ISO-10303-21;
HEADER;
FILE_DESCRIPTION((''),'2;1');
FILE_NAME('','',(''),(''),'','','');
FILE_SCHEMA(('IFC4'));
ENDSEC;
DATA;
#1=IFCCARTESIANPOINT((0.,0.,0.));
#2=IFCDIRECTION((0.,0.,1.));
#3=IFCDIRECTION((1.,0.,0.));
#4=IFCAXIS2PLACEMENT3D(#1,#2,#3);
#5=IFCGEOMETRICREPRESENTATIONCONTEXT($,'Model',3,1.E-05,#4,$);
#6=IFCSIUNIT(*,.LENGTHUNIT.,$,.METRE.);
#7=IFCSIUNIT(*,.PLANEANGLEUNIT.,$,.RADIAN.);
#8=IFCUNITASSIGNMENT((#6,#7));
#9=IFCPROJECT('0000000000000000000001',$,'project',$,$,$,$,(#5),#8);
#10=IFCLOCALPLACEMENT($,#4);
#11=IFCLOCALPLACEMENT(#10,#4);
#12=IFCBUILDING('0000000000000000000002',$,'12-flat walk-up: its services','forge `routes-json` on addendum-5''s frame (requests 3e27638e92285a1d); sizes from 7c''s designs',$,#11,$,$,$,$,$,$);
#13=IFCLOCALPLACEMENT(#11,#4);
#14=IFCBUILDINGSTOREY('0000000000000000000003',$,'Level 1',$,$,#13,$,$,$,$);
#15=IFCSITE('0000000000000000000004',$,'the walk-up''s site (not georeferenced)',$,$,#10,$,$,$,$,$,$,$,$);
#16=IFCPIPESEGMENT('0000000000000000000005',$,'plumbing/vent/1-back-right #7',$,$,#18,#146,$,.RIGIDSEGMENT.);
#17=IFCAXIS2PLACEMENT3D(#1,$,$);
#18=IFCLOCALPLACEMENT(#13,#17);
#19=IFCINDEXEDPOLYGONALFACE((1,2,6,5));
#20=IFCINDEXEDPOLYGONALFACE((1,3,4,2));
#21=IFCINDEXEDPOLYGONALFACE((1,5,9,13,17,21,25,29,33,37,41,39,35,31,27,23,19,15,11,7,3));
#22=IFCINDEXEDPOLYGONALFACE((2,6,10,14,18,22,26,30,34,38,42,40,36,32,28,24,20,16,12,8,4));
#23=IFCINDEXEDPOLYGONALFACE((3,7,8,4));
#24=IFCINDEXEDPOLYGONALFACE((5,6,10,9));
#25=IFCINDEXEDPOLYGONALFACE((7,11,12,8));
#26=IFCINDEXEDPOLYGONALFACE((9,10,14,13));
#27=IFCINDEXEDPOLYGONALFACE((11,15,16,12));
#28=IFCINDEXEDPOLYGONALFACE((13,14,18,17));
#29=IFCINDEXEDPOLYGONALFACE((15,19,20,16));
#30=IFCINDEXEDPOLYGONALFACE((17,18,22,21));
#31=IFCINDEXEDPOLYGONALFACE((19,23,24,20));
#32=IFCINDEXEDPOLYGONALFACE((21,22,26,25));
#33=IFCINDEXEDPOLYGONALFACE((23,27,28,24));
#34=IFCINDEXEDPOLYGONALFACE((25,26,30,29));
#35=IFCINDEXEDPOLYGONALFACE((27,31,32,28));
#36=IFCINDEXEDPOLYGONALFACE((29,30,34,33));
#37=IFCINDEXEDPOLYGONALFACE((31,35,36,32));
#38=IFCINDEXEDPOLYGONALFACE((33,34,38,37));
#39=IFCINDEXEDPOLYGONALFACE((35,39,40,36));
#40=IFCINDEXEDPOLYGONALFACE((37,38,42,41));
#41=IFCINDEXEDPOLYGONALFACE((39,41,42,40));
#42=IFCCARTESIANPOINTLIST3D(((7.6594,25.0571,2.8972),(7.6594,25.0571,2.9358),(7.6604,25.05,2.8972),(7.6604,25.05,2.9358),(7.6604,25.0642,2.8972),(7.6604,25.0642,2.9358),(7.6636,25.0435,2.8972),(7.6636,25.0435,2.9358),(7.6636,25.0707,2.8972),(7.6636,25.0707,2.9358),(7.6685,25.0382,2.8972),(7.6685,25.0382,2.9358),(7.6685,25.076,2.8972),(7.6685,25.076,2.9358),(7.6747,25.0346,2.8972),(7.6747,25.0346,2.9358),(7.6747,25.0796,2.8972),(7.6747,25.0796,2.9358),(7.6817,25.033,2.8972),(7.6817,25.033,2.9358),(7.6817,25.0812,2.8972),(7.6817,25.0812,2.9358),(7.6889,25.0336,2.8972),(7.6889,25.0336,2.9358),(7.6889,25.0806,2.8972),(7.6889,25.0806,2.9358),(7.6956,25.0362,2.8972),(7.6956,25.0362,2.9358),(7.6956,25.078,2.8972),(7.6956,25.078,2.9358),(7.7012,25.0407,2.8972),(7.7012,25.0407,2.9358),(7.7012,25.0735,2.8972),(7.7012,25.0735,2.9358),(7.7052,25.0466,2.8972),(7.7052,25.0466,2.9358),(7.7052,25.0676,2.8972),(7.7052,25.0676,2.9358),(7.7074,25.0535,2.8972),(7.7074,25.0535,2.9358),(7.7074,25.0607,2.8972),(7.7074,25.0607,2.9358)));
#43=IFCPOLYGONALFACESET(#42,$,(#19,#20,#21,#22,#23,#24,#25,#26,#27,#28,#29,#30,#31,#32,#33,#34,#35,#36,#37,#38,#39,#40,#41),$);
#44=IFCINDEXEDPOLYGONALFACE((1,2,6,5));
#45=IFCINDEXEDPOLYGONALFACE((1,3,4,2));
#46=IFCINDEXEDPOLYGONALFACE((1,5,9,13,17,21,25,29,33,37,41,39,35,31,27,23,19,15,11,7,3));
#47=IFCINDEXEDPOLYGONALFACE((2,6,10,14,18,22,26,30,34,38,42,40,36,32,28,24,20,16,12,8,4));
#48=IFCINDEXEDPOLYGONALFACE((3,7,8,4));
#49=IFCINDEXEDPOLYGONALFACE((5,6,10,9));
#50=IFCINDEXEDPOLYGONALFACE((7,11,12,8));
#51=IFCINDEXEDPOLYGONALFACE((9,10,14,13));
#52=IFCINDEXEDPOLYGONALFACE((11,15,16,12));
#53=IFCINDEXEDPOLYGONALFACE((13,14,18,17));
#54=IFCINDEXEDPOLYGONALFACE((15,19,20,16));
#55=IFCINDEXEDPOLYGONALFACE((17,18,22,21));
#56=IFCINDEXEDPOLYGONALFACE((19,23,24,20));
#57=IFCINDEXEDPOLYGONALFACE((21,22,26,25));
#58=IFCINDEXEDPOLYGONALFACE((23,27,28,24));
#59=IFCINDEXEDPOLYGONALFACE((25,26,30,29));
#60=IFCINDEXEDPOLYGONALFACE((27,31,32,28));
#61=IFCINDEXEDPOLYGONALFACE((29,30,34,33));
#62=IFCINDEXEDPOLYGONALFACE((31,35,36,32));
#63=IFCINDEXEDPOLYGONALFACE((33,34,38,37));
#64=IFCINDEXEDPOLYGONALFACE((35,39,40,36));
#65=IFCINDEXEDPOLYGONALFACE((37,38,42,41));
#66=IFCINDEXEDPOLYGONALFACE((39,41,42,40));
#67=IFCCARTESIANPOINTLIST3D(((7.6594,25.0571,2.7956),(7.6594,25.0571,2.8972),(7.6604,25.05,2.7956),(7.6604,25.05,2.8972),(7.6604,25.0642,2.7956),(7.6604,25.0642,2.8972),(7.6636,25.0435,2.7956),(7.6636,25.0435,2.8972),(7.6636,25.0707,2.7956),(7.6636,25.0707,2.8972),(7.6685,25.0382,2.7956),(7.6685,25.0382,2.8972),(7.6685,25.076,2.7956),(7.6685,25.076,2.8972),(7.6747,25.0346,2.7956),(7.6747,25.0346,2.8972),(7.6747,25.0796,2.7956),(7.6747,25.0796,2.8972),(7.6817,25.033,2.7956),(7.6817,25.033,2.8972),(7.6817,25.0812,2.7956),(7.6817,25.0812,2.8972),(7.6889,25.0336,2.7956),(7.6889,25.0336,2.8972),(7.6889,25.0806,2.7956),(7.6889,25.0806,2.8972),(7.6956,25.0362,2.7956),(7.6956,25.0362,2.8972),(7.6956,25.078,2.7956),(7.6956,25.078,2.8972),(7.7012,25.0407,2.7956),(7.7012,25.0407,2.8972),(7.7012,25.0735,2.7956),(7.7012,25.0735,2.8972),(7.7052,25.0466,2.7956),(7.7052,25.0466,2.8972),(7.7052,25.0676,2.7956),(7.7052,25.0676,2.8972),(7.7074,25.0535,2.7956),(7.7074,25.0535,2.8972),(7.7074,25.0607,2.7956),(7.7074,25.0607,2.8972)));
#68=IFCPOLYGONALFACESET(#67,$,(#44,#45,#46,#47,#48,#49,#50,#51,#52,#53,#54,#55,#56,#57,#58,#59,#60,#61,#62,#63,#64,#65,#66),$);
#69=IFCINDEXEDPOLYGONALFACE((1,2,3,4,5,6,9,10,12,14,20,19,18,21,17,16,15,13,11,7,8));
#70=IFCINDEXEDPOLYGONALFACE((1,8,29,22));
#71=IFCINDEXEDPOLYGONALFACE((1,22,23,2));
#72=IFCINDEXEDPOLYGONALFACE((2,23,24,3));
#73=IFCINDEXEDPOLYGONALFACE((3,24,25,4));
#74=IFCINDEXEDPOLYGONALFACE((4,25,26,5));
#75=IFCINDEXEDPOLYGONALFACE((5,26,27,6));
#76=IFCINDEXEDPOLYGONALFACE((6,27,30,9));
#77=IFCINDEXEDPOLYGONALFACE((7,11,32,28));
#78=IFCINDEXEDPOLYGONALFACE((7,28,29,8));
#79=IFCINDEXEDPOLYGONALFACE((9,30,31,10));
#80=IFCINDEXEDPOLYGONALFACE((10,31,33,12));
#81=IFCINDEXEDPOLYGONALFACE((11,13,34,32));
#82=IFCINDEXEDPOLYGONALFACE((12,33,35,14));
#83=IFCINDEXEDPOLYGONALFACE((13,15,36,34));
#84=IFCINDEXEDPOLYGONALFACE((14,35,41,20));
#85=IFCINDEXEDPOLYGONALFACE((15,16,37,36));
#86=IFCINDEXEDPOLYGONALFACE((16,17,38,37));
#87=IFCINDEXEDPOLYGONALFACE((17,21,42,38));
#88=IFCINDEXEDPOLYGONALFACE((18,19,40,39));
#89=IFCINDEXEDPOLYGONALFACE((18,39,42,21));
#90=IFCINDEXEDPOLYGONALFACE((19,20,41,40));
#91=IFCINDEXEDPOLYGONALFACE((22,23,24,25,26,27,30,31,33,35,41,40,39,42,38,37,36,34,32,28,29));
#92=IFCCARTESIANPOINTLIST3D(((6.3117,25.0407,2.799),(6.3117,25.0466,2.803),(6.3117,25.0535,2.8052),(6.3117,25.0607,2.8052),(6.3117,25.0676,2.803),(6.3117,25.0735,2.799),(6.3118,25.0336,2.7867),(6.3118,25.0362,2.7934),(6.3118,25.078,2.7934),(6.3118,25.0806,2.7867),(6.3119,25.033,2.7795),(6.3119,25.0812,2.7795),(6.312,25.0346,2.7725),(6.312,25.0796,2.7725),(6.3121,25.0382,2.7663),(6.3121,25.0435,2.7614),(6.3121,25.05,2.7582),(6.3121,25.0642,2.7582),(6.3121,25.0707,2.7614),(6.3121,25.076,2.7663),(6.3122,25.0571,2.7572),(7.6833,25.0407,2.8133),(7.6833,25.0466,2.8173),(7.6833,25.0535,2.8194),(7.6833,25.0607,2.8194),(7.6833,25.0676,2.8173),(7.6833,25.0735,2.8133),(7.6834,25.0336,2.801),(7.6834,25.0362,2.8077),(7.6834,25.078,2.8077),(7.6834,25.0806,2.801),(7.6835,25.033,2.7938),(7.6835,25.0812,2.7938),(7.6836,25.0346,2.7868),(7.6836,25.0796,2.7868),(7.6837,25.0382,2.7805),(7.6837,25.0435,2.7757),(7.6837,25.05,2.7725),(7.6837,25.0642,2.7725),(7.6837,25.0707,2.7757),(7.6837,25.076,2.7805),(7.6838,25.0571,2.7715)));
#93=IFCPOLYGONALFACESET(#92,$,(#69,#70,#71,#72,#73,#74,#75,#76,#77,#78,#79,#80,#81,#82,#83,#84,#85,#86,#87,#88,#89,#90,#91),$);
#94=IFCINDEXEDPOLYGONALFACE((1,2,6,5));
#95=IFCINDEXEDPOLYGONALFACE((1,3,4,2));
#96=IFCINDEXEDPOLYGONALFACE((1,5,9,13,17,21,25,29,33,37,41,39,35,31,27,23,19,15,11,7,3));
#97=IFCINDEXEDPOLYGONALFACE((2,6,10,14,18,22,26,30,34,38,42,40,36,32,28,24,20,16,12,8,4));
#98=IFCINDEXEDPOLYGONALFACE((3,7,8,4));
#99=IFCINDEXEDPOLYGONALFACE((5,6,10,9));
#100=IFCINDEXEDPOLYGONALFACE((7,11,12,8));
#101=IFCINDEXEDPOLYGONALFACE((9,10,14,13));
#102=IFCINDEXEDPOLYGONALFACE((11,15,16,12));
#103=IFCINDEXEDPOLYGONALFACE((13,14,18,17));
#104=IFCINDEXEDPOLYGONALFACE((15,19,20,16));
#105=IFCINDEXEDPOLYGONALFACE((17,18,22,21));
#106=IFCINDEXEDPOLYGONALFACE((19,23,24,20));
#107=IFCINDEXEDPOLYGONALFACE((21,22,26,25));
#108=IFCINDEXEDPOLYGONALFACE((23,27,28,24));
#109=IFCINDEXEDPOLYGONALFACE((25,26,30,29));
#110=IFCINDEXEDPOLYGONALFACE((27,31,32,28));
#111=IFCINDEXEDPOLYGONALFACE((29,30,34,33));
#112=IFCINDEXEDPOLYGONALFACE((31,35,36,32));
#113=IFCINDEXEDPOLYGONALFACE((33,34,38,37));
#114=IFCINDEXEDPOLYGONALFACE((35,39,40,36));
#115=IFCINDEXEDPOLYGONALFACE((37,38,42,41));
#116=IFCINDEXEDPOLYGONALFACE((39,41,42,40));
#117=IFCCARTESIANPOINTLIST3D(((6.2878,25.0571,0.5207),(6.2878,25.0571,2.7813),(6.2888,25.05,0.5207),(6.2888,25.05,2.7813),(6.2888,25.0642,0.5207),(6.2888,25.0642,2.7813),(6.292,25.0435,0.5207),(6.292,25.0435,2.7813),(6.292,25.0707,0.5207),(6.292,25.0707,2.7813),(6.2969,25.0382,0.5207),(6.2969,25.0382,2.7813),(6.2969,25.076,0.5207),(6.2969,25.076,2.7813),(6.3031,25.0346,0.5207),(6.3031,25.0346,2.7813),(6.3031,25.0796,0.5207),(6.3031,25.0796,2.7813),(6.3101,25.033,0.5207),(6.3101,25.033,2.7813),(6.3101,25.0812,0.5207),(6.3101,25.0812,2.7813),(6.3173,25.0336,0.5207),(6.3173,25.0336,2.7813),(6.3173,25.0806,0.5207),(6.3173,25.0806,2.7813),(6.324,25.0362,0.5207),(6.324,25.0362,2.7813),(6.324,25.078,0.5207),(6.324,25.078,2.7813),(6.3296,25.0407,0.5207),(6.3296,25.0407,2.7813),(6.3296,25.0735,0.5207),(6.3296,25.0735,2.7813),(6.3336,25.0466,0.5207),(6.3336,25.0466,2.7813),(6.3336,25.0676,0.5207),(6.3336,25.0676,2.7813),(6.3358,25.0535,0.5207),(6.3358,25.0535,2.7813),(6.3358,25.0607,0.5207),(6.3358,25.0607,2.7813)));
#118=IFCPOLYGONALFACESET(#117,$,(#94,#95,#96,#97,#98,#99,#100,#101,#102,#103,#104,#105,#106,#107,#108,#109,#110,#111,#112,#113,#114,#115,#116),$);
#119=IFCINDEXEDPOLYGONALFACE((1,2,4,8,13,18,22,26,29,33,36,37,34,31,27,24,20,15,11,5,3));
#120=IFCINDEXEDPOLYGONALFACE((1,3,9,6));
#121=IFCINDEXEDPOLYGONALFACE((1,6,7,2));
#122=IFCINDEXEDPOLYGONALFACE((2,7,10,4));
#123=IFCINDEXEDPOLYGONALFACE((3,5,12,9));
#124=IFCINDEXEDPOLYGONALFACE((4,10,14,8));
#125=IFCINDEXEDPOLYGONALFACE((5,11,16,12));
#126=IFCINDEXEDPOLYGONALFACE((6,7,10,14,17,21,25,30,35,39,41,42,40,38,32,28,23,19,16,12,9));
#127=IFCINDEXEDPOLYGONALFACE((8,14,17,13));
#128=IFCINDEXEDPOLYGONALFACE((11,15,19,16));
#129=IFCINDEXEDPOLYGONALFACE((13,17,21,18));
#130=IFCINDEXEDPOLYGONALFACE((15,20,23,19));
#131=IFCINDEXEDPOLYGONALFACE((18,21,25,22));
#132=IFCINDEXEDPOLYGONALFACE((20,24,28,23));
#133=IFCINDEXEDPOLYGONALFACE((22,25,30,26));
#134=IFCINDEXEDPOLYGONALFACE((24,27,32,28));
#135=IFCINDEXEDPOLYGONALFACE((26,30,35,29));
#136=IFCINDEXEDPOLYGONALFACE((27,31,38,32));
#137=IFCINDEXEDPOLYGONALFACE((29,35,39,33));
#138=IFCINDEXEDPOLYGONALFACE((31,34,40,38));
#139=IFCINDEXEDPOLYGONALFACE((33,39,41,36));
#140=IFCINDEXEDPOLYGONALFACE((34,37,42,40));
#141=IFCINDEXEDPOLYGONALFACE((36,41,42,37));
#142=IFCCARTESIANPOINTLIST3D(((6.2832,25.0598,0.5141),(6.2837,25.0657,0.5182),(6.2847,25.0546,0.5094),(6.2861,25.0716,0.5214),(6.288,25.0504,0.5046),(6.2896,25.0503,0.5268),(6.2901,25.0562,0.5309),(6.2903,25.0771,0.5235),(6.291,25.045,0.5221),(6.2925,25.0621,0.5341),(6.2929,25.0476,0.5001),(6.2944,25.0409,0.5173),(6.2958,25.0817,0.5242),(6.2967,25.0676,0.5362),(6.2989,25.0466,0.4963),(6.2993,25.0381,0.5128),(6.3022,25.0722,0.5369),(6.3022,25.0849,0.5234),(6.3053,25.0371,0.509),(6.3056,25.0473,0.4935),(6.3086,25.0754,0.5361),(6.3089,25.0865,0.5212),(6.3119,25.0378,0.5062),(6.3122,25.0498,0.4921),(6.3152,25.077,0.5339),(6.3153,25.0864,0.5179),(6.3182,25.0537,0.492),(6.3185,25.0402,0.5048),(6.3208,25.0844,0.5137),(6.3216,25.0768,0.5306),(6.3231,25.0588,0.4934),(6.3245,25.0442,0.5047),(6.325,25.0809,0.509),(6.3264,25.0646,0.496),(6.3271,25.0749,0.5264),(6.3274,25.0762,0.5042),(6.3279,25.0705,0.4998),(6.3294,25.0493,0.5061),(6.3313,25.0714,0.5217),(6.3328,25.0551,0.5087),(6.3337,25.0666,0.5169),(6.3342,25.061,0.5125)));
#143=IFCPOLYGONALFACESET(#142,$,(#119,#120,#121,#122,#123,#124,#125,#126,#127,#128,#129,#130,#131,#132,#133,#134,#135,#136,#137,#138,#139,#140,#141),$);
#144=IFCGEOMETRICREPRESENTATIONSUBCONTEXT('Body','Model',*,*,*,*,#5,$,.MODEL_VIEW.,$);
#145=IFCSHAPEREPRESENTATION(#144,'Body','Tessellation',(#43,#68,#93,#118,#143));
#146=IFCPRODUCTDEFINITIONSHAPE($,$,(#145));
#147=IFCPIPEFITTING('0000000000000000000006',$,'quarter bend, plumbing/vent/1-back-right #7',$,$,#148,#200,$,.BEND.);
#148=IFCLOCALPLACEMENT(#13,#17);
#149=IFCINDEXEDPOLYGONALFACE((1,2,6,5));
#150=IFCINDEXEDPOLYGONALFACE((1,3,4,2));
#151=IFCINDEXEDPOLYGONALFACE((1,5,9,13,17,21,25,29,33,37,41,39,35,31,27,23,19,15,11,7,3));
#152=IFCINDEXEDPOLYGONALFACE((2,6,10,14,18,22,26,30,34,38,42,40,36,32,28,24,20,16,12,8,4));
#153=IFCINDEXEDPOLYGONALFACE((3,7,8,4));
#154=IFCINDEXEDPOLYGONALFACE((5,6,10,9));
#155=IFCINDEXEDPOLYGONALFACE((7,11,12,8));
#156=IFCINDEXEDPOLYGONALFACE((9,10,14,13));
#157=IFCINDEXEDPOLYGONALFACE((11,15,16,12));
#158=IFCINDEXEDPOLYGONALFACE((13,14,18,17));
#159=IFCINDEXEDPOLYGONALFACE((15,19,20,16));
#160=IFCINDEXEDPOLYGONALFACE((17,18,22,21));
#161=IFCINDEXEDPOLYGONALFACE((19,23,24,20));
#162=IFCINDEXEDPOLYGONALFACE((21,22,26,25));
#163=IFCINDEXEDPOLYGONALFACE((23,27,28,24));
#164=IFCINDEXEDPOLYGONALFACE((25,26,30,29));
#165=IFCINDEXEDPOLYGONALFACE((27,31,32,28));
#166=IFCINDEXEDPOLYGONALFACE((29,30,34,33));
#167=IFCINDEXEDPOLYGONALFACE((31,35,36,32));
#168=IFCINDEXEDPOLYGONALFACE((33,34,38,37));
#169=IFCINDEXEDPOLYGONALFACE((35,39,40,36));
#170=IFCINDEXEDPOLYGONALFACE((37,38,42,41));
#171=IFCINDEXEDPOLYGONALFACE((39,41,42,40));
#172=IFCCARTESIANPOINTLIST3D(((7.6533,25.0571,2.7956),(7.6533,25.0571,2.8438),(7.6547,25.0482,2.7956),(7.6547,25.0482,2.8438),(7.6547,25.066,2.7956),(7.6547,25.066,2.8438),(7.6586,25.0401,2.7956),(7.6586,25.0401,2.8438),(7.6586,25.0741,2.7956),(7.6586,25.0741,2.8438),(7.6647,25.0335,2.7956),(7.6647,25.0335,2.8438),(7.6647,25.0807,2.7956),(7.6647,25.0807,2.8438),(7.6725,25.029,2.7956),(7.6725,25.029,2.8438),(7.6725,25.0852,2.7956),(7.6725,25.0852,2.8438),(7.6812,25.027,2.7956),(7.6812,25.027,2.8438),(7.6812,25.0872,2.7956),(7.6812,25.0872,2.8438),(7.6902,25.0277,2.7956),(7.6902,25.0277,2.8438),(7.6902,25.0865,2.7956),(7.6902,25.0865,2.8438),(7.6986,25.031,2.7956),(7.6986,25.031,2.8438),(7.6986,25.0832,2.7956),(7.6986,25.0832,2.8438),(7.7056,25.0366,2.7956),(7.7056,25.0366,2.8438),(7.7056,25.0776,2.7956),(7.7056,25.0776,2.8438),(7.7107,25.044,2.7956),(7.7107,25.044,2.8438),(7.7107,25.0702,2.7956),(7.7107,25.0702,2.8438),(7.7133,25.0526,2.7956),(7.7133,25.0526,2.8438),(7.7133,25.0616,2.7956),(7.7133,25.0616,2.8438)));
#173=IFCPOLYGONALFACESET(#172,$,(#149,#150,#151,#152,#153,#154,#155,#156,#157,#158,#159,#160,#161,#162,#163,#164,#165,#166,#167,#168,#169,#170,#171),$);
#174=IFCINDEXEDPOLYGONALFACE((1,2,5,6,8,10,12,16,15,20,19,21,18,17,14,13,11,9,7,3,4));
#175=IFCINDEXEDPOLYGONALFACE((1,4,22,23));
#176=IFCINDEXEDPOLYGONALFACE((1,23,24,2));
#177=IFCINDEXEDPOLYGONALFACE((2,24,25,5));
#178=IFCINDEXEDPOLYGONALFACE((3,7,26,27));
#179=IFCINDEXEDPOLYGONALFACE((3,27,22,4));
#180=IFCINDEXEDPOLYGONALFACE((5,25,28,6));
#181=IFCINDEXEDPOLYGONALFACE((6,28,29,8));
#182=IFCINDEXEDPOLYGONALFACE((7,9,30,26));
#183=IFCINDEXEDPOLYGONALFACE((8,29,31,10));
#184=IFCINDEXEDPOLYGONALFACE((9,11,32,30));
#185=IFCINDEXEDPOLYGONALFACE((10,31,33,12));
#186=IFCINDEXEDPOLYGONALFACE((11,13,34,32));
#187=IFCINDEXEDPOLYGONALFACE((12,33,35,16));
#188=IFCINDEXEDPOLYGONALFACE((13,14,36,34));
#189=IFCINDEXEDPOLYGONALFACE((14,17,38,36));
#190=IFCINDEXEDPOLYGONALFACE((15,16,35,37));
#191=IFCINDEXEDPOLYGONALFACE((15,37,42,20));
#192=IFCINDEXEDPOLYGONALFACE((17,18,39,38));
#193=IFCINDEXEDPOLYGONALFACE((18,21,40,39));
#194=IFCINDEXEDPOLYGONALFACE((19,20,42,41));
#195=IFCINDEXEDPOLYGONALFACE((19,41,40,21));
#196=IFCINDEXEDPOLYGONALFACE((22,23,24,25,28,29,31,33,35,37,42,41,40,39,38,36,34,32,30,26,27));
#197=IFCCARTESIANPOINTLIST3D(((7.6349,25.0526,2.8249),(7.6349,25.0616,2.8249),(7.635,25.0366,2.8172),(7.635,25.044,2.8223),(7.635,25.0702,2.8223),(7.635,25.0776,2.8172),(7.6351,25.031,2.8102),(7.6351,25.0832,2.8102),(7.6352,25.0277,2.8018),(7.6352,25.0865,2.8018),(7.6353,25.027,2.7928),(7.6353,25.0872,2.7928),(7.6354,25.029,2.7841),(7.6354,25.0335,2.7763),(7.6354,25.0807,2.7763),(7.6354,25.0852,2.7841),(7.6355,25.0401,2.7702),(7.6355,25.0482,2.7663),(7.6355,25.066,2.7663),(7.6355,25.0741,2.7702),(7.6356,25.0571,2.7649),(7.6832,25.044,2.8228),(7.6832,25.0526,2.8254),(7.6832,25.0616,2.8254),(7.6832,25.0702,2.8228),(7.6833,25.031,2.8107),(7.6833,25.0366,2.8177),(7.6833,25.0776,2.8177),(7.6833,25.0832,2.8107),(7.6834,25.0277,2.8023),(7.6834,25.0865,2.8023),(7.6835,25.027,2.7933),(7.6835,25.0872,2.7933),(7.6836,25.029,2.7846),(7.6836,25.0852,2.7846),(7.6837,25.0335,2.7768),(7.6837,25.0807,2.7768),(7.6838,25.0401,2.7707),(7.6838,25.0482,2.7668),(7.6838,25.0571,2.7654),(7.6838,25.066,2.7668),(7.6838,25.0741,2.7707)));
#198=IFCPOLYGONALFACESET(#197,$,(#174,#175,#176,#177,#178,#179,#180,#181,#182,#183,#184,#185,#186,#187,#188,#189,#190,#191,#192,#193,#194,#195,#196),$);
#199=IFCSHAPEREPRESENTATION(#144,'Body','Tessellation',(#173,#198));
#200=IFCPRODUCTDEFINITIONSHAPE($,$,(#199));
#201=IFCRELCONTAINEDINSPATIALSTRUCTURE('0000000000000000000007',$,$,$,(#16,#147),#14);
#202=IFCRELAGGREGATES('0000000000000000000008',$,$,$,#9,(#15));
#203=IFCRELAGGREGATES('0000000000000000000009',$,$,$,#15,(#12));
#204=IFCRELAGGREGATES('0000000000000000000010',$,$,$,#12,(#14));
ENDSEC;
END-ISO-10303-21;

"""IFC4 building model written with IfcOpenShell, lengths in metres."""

from ifc_helpers import new_model, entity, si_unit, frame, origin_with_axes, place, context, subcontext, project, spatial, element, save


model = new_model("IFC4")

# Units and contexts
model_context = context("Model", 3, precision=1e-05, world=origin_with_axes())
body_context = subcontext(model_context, "Body", "Model", "MODEL_VIEW")
ifc_project = project(units=[si_unit("LENGTHUNIT", "METRE"), si_unit("PLANEANGLEUNIT", "RADIAN")], contexts=[model_context])

# Site, building, storey
site_placement = place(None, origin_with_axes())
site = spatial("IfcSite", under=ifc_project, at=site_placement, Name="the walk-up's site (not georeferenced)")
building_placement = place(site_placement, origin_with_axes())
building = spatial("IfcBuilding", under=site, at=building_placement, Name="12-flat walk-up: its services", Description="forge `routes-json` on addendum-5's frame (requests 3e27638e92285a1d); sizes from 7c's designs")
storey_placement = place(building_placement, origin_with_axes())
storey = spatial("IfcBuildingStorey", under=building, at=storey_placement, Name="Level 1")

# Pipe segment
pipe_segment_1_placement = place(storey_placement, frame((7.6835, 25.0571, 2.9358), z_axis=(0.0, 0.0, 1.0), x_axis=(1.0, 0.0, 0.0)))
element("IfcPipeSegment", 1, at=pipe_segment_1_placement, inside=storey, Name="plumbing/vent/1-back-right #7", PredefinedType="RIGIDSEGMENT", context=body_context, shape_type="AdvancedSweptSolid", body=[
    entity("IfcSweptDiskSolid", entity("IfcPolyline", [entity("IfcCartesianPoint", [0.0, 0.0, 0.0]), entity("IfcCartesianPoint", [0.0, 0.0, -0.0386])]), 0.0241),
    entity("IfcSweptDiskSolid", entity("IfcPolyline", [entity("IfcCartesianPoint", [0.0, 0.0, -0.0386]), entity("IfcCartesianPoint", [0.0, 0.0, -0.1402])]), 0.0241),
    entity("IfcSweptDiskSolid", entity("IfcPolyline", [entity("IfcCartesianPoint", [0.0, 0.0, -0.1402]), entity("IfcCartesianPoint", [-1.3716, 0.0, -0.1545])]), 0.0241),
    entity("IfcSweptDiskSolid", entity("IfcPolyline", [entity("IfcCartesianPoint", [-1.3716, 0.0, -0.1545]), entity("IfcCartesianPoint", [-1.3716, 0.0, -2.4151])]), 0.0241),
    entity("IfcSweptDiskSolid", entity("IfcPolyline", [entity("IfcCartesianPoint", [-1.3716, 0.0, -2.4151]), entity("IfcCartesianPoint", [-1.3779, 0.0095, -2.4278])]), 0.0241),
])

# Pipe fitting
pipe_fitting_1_placement = place(storey_placement, frame((7.6835, 25.0571, 2.8438), z_axis=(0.0, 0.0, 1.0), x_axis=(1.0, 0.0, 0.0)))
element("IfcPipeFitting", 2, at=pipe_fitting_1_placement, inside=storey, Name="quarter bend, plumbing/vent/1-back-right #7", PredefinedType="BEND", context=body_context, shape_type="AdvancedSweptSolid", body=[
    entity("IfcSweptDiskSolid", entity("IfcPolyline", [entity("IfcCartesianPoint", [0.0, 0.0, 0.0]), entity("IfcCartesianPoint", [0.0, 0.0, -0.0483])]), 0.0302),
    entity("IfcSweptDiskSolid", entity("IfcPolyline", [entity("IfcCartesianPoint", [0.0, 0.0, -0.0483]), entity("IfcCartesianPoint", [-0.0483, 0.0, -0.0488])]), 0.0302),
])

save(model, "model.ifc")
